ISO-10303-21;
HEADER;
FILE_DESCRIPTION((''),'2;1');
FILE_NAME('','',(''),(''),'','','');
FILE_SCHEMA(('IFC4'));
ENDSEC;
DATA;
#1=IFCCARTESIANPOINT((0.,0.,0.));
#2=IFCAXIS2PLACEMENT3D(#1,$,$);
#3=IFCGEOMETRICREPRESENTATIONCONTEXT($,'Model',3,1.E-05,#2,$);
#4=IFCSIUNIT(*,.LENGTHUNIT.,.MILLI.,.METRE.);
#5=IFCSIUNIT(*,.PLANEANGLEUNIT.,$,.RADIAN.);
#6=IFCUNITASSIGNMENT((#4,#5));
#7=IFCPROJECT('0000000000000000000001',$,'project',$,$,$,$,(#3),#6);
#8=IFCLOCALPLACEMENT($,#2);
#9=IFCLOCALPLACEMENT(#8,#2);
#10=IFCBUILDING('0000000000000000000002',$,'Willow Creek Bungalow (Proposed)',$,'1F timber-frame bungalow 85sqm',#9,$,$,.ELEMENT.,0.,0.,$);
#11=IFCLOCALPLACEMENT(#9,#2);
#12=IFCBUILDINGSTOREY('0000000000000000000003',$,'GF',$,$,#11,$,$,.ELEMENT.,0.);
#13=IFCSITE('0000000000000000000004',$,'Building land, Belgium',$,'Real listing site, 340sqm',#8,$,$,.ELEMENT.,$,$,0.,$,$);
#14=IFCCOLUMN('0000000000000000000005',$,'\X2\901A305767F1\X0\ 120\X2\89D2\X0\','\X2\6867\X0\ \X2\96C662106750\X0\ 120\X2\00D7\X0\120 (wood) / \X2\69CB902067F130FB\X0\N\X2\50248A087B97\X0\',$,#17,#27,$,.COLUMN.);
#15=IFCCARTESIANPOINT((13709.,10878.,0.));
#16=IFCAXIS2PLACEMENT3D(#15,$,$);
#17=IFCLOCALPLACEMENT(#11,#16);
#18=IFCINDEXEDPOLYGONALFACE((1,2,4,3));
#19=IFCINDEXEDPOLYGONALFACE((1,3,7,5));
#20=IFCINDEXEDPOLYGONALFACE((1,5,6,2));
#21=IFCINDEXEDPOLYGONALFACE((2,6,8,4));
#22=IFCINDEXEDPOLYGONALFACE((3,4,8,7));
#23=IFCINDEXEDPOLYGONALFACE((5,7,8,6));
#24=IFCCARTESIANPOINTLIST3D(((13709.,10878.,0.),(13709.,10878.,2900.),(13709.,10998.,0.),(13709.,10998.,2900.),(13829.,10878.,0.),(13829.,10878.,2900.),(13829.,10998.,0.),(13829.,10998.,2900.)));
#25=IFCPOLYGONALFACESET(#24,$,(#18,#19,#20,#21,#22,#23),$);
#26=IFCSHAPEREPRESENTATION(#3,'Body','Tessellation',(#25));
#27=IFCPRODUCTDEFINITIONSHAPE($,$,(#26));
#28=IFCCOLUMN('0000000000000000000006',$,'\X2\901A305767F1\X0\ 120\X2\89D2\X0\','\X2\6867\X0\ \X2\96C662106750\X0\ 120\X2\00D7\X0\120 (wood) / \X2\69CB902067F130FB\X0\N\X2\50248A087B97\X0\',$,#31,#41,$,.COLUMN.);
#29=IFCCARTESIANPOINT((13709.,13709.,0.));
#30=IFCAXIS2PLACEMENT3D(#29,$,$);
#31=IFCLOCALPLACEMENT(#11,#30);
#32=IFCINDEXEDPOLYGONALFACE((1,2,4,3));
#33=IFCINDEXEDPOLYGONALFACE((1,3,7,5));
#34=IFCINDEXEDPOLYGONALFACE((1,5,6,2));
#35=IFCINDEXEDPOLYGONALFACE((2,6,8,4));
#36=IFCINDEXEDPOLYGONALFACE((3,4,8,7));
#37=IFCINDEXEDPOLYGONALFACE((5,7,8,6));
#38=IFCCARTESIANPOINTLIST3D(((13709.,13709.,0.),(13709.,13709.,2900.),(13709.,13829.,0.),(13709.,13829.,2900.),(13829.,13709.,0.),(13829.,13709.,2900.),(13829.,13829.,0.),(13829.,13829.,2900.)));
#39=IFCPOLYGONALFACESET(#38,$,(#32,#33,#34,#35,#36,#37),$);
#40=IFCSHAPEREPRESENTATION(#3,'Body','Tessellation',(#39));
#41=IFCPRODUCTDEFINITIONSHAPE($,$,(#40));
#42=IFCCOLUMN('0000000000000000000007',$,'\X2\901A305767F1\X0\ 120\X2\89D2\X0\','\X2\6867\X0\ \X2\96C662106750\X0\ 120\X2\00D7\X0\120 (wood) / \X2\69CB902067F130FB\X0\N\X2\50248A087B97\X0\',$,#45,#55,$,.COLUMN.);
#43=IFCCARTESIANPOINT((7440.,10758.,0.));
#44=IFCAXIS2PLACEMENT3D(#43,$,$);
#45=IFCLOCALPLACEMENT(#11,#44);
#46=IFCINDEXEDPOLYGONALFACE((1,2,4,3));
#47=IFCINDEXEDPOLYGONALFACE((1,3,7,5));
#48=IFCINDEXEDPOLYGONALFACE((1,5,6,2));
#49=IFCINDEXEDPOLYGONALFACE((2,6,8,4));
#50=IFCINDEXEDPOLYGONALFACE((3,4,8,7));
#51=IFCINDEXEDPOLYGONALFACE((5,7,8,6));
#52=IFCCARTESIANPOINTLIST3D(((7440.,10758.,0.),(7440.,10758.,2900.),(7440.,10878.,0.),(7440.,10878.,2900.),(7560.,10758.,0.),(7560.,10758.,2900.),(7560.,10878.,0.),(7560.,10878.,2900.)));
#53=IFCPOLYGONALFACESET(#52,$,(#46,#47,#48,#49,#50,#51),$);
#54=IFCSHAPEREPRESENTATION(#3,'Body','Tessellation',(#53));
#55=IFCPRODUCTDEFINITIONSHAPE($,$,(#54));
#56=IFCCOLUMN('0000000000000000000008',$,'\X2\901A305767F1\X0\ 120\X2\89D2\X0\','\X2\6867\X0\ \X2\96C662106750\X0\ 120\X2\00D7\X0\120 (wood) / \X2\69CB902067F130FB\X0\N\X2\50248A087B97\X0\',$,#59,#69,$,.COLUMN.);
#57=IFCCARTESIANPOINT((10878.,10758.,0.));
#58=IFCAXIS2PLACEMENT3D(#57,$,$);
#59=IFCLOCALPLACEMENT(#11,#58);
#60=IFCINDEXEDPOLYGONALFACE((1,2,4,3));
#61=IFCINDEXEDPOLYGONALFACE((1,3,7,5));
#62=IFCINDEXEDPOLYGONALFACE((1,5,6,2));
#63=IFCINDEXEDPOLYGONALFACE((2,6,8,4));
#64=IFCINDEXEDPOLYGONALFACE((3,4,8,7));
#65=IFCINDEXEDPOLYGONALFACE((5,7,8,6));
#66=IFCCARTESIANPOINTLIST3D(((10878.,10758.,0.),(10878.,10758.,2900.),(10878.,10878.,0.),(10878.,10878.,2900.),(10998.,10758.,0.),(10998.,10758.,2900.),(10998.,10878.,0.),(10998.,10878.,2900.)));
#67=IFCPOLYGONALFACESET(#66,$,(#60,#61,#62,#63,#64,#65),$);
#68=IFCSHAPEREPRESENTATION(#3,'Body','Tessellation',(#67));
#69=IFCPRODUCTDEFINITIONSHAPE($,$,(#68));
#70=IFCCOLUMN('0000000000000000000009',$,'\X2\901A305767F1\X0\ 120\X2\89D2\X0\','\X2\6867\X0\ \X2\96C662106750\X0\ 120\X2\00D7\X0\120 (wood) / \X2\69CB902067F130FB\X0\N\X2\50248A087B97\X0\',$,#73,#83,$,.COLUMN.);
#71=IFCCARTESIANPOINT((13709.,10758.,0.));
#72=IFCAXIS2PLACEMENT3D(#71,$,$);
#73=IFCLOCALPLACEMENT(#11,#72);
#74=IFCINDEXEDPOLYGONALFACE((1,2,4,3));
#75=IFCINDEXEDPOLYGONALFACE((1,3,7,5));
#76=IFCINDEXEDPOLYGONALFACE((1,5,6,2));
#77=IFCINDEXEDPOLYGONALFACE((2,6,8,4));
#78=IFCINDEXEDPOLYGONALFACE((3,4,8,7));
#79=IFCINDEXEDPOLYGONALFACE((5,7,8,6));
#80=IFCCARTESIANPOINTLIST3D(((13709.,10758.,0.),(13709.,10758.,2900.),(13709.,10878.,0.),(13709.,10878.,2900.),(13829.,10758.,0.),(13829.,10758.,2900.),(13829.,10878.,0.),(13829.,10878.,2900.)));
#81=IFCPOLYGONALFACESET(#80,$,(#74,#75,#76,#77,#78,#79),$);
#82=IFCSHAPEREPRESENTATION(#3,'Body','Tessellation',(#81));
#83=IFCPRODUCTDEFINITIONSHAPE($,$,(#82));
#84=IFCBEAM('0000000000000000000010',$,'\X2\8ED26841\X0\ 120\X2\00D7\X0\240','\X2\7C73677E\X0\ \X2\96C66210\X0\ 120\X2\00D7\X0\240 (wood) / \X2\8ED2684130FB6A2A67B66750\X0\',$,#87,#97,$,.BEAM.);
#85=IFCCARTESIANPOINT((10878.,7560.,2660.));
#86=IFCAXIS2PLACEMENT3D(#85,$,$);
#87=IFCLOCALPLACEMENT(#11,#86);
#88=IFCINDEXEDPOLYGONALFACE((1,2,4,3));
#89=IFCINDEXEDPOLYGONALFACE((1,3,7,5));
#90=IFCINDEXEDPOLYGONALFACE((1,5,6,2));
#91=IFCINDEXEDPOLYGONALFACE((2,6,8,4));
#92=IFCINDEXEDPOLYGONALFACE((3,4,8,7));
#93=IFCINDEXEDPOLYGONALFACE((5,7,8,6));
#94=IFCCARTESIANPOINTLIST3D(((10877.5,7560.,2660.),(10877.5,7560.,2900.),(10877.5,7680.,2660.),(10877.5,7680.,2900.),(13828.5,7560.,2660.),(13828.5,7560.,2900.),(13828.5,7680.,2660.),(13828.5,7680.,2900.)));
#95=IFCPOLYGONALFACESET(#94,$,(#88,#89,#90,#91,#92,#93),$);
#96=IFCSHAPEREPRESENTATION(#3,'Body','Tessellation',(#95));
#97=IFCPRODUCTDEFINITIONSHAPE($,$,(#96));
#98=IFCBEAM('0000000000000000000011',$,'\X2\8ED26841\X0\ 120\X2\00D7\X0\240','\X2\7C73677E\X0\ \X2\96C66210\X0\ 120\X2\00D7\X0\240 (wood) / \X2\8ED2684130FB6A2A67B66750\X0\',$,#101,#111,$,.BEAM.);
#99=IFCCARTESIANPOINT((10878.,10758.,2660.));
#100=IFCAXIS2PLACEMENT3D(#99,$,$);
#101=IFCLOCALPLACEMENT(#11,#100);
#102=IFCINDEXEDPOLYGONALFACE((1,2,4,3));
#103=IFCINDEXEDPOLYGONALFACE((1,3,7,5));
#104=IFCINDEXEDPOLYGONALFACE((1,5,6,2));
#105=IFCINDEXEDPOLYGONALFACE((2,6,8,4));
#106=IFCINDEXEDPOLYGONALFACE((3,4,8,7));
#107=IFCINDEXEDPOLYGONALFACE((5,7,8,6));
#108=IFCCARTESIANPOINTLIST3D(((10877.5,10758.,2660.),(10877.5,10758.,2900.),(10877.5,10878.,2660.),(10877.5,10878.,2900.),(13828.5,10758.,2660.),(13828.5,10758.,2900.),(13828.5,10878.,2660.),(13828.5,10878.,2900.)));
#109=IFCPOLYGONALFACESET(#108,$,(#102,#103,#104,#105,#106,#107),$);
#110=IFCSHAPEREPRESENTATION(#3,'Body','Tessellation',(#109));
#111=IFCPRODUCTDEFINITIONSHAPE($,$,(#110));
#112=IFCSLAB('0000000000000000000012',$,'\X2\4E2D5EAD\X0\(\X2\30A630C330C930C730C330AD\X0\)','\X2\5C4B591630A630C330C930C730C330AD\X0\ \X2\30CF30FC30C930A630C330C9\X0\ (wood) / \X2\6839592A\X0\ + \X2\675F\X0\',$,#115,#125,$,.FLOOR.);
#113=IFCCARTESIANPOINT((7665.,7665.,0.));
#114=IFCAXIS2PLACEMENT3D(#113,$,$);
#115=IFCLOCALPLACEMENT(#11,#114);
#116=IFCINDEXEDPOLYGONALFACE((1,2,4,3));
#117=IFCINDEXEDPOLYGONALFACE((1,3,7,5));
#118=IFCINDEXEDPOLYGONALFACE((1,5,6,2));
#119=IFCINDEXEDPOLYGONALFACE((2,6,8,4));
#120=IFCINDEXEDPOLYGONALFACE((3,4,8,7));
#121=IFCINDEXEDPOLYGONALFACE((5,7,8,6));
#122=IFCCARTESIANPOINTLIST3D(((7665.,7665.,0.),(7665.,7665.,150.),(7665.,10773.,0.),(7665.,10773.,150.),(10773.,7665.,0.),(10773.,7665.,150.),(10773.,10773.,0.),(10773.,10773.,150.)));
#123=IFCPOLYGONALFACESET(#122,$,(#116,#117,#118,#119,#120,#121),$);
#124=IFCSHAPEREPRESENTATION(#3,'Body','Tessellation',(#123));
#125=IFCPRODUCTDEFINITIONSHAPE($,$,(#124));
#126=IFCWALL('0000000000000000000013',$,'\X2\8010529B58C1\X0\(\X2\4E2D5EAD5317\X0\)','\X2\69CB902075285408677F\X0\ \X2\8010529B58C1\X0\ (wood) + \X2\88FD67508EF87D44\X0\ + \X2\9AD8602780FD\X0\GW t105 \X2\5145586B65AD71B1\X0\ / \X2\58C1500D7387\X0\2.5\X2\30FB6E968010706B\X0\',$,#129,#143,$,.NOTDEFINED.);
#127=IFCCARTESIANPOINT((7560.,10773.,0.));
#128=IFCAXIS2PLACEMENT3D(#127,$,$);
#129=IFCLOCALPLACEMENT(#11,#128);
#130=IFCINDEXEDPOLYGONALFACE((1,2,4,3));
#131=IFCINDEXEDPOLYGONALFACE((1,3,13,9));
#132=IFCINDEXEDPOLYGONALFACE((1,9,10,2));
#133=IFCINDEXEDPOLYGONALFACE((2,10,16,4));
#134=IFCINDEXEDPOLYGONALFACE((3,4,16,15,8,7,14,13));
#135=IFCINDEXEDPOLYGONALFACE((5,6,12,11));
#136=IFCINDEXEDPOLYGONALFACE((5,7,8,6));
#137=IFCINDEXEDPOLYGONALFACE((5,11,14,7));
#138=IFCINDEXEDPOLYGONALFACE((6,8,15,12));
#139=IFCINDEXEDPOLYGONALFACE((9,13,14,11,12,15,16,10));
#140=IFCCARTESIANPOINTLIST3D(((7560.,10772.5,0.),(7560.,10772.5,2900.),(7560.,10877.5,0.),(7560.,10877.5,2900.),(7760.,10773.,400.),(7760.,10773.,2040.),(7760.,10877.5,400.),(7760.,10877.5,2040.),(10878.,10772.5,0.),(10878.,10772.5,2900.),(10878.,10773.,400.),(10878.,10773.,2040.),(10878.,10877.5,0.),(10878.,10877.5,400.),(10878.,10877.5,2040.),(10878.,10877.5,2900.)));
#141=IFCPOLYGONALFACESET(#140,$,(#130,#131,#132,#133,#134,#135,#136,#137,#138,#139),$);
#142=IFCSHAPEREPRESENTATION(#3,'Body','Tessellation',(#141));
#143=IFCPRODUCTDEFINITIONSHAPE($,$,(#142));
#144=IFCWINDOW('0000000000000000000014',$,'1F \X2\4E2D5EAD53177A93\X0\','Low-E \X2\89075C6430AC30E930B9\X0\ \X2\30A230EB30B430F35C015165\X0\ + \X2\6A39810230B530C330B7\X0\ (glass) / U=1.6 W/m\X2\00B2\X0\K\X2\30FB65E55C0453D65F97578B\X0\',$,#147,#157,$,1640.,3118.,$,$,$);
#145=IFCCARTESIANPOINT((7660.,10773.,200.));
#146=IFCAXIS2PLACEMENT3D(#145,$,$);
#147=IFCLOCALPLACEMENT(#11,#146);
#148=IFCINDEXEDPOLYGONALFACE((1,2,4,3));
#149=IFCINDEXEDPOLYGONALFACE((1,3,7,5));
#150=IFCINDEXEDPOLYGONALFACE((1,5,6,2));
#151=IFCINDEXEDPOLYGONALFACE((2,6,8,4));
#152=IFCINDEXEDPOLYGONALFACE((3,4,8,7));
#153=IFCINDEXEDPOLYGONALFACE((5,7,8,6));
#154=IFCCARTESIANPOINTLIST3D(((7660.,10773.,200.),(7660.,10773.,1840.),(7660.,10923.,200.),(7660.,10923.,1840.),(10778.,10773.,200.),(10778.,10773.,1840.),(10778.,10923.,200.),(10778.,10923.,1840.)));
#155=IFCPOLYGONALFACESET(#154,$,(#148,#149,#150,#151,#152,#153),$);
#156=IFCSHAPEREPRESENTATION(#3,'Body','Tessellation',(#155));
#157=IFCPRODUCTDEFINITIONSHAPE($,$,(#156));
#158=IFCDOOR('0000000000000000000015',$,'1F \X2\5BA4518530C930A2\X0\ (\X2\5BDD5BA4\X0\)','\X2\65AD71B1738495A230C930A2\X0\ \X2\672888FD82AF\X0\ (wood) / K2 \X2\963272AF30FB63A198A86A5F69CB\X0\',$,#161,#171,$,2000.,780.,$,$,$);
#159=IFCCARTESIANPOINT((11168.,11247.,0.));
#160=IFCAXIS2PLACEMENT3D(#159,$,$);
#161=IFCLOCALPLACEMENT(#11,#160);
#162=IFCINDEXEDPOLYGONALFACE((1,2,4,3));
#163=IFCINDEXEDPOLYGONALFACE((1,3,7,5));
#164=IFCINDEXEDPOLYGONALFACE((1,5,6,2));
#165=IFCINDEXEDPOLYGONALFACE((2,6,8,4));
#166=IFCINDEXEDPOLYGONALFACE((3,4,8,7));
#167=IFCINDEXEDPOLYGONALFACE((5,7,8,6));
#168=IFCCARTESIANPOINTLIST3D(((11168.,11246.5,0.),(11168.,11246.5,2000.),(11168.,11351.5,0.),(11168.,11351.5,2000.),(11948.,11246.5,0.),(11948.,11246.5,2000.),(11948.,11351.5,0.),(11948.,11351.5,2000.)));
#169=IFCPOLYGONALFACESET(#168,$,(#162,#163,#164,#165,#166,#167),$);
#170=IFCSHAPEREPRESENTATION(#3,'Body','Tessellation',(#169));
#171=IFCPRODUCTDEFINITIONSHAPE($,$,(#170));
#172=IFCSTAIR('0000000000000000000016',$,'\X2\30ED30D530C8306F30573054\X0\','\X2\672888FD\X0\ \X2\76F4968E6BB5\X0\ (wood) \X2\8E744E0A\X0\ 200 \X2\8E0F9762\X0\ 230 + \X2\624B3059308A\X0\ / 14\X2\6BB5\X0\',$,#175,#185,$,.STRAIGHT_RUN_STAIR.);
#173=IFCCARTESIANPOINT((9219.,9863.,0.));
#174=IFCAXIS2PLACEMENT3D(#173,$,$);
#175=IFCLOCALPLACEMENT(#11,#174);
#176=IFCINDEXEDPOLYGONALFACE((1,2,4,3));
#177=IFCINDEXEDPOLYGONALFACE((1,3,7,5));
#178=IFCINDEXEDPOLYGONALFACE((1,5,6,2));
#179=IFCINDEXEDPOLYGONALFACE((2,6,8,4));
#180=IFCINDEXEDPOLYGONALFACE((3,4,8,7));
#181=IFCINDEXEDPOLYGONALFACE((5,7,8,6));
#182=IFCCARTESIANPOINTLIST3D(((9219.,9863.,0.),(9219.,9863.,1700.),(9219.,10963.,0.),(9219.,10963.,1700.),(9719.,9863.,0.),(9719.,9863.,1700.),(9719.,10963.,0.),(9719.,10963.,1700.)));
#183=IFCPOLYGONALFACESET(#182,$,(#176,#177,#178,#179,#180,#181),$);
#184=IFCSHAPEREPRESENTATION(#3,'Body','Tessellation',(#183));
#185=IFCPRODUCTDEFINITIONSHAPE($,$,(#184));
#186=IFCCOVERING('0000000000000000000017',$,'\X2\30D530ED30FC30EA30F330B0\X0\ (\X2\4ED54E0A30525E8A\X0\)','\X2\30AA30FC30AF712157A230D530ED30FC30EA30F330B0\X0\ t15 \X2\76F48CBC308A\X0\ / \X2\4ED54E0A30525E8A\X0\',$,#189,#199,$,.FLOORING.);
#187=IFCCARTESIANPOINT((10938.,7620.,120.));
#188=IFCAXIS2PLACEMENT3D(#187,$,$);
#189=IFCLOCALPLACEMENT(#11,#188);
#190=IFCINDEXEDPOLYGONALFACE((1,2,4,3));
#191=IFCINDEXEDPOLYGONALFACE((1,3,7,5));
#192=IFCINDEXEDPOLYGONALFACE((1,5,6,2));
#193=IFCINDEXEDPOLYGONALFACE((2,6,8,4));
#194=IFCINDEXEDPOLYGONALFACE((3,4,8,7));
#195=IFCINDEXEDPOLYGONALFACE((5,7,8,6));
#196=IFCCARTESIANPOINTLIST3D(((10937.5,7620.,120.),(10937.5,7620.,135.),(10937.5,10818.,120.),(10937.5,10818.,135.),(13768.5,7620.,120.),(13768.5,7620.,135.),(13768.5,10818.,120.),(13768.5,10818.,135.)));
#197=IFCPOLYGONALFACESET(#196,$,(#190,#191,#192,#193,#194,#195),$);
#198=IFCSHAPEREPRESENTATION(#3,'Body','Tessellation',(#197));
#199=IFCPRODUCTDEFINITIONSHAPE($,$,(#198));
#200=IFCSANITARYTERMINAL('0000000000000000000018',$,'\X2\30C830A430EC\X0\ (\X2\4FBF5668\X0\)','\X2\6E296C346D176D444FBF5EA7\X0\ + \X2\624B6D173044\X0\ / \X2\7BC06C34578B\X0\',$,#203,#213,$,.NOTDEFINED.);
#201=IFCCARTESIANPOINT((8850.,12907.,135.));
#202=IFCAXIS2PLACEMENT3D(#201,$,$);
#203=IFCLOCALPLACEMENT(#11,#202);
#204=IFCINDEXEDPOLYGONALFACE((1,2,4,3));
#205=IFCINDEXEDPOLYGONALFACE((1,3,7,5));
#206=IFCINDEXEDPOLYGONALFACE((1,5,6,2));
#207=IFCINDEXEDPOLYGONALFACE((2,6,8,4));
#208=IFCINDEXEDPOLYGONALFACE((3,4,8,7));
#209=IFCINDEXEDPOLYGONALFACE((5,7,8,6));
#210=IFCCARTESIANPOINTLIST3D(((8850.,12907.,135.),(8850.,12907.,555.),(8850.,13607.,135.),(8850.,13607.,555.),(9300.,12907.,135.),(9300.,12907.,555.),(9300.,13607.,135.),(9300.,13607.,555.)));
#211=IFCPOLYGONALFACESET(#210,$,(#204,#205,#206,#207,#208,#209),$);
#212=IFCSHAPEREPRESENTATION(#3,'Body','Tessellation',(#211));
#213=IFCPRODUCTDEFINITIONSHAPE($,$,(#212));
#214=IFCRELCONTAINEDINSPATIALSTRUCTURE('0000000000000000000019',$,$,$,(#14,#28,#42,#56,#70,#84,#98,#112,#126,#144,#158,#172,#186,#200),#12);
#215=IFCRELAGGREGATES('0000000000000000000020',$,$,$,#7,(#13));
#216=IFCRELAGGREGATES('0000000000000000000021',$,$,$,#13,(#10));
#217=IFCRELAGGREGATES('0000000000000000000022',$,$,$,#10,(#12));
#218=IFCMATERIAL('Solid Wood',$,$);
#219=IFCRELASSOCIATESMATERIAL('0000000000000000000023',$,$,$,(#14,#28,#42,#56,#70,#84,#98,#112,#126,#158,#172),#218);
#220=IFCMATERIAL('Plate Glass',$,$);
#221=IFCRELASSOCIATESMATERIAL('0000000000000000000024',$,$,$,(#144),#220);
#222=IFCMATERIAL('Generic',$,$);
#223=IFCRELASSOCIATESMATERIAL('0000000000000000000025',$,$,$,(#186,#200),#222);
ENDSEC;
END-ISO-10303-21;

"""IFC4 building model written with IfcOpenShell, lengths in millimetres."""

from ifc_helpers import new_model, si_unit, frame, frame_2d, origin, place, context, project, spatial, rectangle, extrude, material, element, fill, save


model = new_model("IFC4")

# Units and contexts
model_context = context("Model", 3, precision=1e-05, world=origin())
ifc_project = project(units=[si_unit("LENGTHUNIT", "METRE", prefix="MILLI"), si_unit("PLANEANGLEUNIT", "RADIAN")], contexts=[model_context])

# Site, building, storey
site_placement = place(None, origin())
site = spatial("IfcSite", under=ifc_project, at=site_placement, Name="Building land, Belgium", ObjectType="Real listing site, 340sqm", CompositionType="ELEMENT", RefElevation=0.0)
building_placement = place(site_placement, origin())
building = spatial("IfcBuilding", under=site, at=building_placement, Name="Willow Creek Bungalow (Proposed)", ObjectType="1F timber-frame bungalow 85sqm", CompositionType="ELEMENT", ElevationOfRefHeight=0.0, ElevationOfTerrain=0.0)
storey_placement = place(building_placement, origin())
storey = spatial("IfcBuildingStorey", under=building, at=storey_placement, Name="GF", CompositionType="ELEMENT", Elevation=0.0)

# Columns
ifc_material_1 = material(Name="Solid Wood")
column_1_placement = place(storey_placement, frame((13709.0, 10878.0, 0.0)))
element("IfcColumn", 1, at=column_1_placement, inside=storey, material=ifc_material_1, Name="通し柱 120角", Description="桧 集成材 120×120 (wood) / 構造柱・N値計算", PredefinedType="COLUMN", context=model_context, shape_type="SweptSolid", body=[
    extrude(rectangle(XDim=120.0, YDim=120.0, at=frame_2d((60.0, 60.0))), frame((13709.0, 10878.0, 0.0)), (0.0, 0.0, 1.0), 2900.0),
])
column_2_placement = place(storey_placement, frame((13709.0, 13709.0, 0.0)))
element("IfcColumn", 2, at=column_2_placement, inside=storey, material=ifc_material_1, Name="通し柱 120角", Description="桧 集成材 120×120 (wood) / 構造柱・N値計算", PredefinedType="COLUMN", context=model_context, shape_type="SweptSolid", body=[
    extrude(rectangle(XDim=120.0, YDim=120.0, at=frame_2d((60.0, 60.0))), frame((13709.0, 13709.0, 0.0)), (0.0, 0.0, 1.0), 2900.0),
])
column_3_placement = place(storey_placement, frame((7440.0, 10758.0, 0.0)))
element("IfcColumn", 3, at=column_3_placement, inside=storey, material=ifc_material_1, Name="通し柱 120角", Description="桧 集成材 120×120 (wood) / 構造柱・N値計算", PredefinedType="COLUMN", context=model_context, shape_type="SweptSolid", body=[
    extrude(rectangle(XDim=120.0, YDim=120.0, at=frame_2d((60.0, 60.0))), frame((7440.0, 10758.0, 0.0)), (0.0, 0.0, 1.0), 2900.0),
])
column_4_placement = place(storey_placement, frame((10878.0, 10758.0, 0.0)))
element("IfcColumn", 4, at=column_4_placement, inside=storey, material=ifc_material_1, Name="通し柱 120角", Description="桧 集成材 120×120 (wood) / 構造柱・N値計算", PredefinedType="COLUMN", context=model_context, shape_type="SweptSolid", body=[
    extrude(rectangle(XDim=120.0, YDim=120.0, at=frame_2d((60.0, 60.0))), frame((10878.0, 10758.0, 0.0)), (0.0, 0.0, 1.0), 2900.0),
])
column_5_placement = place(storey_placement, frame((13709.0, 10758.0, 0.0)))
element("IfcColumn", 5, at=column_5_placement, inside=storey, material=ifc_material_1, Name="通し柱 120角", Description="桧 集成材 120×120 (wood) / 構造柱・N値計算", PredefinedType="COLUMN", context=model_context, shape_type="SweptSolid", body=[
    extrude(rectangle(XDim=120.0, YDim=120.0, at=frame_2d((60.0, 60.0))), frame((13709.0, 10758.0, 0.0)), (0.0, 0.0, 1.0), 2900.0),
])

# Beams
beam_1_placement = place(storey_placement, frame((10878.0, 7560.0, 2660.0)))
element("IfcBeam", 6, at=beam_1_placement, inside=storey, material=ifc_material_1, Name="軒桁 120×240", Description="米松 集成 120×240 (wood) / 軒桁・横架材", PredefinedType="BEAM", context=model_context, shape_type="SweptSolid", body=[
    extrude(rectangle(XDim=2951.0, YDim=120.0, at=frame_2d((1475.0, 60.0))), frame((10878.0, 7560.0, 2660.0)), (0.0, 0.0, 1.0), 240.0),
])
beam_2_placement = place(storey_placement, frame((10878.0, 10758.0, 2660.0)))
element("IfcBeam", 7, at=beam_2_placement, inside=storey, material=ifc_material_1, Name="軒桁 120×240", Description="米松 集成 120×240 (wood) / 軒桁・横架材", PredefinedType="BEAM", context=model_context, shape_type="SweptSolid", body=[
    extrude(rectangle(XDim=2951.0, YDim=120.0, at=frame_2d((1475.0, 60.0))), frame((10878.0, 10758.0, 2660.0)), (0.0, 0.0, 1.0), 240.0),
])

# Slab
slab_placement = place(storey_placement, frame((7665.0, 7665.0, 0.0)))
element("IfcSlab", 8, at=slab_placement, inside=storey, material=ifc_material_1, Name="中庭(ウッドデッキ)", Description="屋外ウッドデッキ ハードウッド (wood) / 根太 + 束", PredefinedType="FLOOR", context=model_context, shape_type="SweptSolid", body=[
    extrude(rectangle(XDim=3108.0, YDim=3108.0, at=frame_2d((1554.0, 1554.0))), frame((7665.0, 7665.0, 0.0)), (0.0, 0.0, 1.0), 150.0),
])

# Wall, opening, window
wall_1_placement = place(storey_placement, frame((7560.0, 10773.0, 0.0)))
wall_1 = element("IfcWall", 9, at=wall_1_placement, inside=storey, material=ifc_material_1, Name="耐力壁(中庭北)", Description="構造用合板 耐力壁 (wood) + 製材軸組 + 高性能GW t105 充填断熱 / 壁倍率2.5・準耐火", PredefinedType="NOTDEFINED", context=model_context, shape_type="SweptSolid", body=[
    extrude(rectangle(XDim=3318.0, YDim=105.0, at=frame_2d((1659.0, 52.0))), frame((7560.0, 10773.0, 0.0)), (0.0, 0.0, 1.0), 2900.0),
])
opening_placement = place(storey_placement, frame((7660.0, 10773.0, 200.0)))
opening = element("IfcOpeningElement", 10, at=opening_placement, cuts=wall_1, PredefinedType="NOTDEFINED", context=model_context, shape_type="SweptSolid", body=[
    extrude(rectangle(XDim=3118.0, YDim=150.0, at=frame_2d((1559.0, 75.0))), frame((7660.0, 10773.0, 200.0)), (0.0, 0.0, 1.0), 1640.0),
])
ifc_material_2 = material(Name="Plate Glass")
window_placement = place(storey_placement, frame((7660.0, 10773.0, 200.0)))
window = element("IfcWindow", 11, at=window_placement, inside=storey, material=ifc_material_2, Name="1F 中庭北窓", Description="Low-E 複層ガラス アルゴン封入 + 樹脂サッシ (glass) / U=1.6 W/m²K・日射取得型", OverallHeight=1640.0, OverallWidth=3118.0, context=model_context, shape_type="SweptSolid", body=[
    extrude(rectangle(XDim=3118.0, YDim=150.0, at=frame_2d((1559.0, 75.0))), frame((7660.0, 10773.0, 200.0)), (0.0, 0.0, 1.0), 1640.0),
])
fill(opening, window)

# Door
door_placement = place(storey_placement, frame((11168.0, 11247.0, 0.0)))
element("IfcDoor", 12, at=door_placement, inside=storey, material=ifc_material_1, Name="1F 室内ドア (寝室)", Description="断熱玄関ドア 木製芯 (wood) / K2 防犯・採風機構", OverallHeight=2000.0, OverallWidth=780.0, context=model_context, shape_type="SweptSolid", body=[
    extrude(rectangle(XDim=780.0, YDim=105.0, at=frame_2d((390.0, 52.0))), frame((11168.0, 11247.0, 0.0)), (0.0, 0.0, 1.0), 2000.0),
])

# Stair
stair_placement = place(storey_placement, frame((9219.0, 9863.0, 0.0)))
element("IfcStair", 13, at=stair_placement, inside=storey, material=ifc_material_1, Name="ロフトはしご", Description="木製 直階段 (wood) 蹴上 200 踏面 230 + 手すり / 14段", PredefinedType="STRAIGHT_RUN_STAIR", context=model_context, shape_type="SweptSolid", body=[
    extrude(rectangle(XDim=500.0, YDim=1100.0, at=frame_2d((250.0, 550.0))), frame((9219.0, 9863.0, 0.0)), (0.0, 0.0, 1.0), 1700.0),
])

# Covering
ifc_material_3 = material(Name="Generic")
covering_placement = place(storey_placement, frame((10938.0, 7620.0, 120.0)))
element("IfcCovering", 14, at=covering_placement, inside=storey, material=ifc_material_3, Name="フローリング (仕上げ床)", Description="オーク無垢フローリング t15 直貼り / 仕上げ床", PredefinedType="FLOORING", context=model_context, shape_type="SweptSolid", body=[
    extrude(rectangle(XDim=2831.0, YDim=3198.0, at=frame_2d((1415.0, 1599.0))), frame((10938.0, 7620.0, 120.0)), (0.0, 0.0, 1.0), 15.0),
])

# Sanitary terminal
sanitary_terminal_placement = place(storey_placement, frame((8850.0, 12907.0, 135.0)))
element("IfcSanitaryTerminal", 15, at=sanitary_terminal_placement, inside=storey, material=ifc_material_3, Name="トイレ (便器)", Description="温水洗浄便座 + 手洗い / 節水型", PredefinedType="NOTDEFINED", context=model_context, shape_type="SweptSolid", body=[
    extrude(rectangle(XDim=450.0, YDim=700.0, at=frame_2d((225.0, 350.0))), frame((8850.0, 12907.0, 135.0)), (0.0, 0.0, 1.0), 420.0),
])

save(model, "model.ifc")
